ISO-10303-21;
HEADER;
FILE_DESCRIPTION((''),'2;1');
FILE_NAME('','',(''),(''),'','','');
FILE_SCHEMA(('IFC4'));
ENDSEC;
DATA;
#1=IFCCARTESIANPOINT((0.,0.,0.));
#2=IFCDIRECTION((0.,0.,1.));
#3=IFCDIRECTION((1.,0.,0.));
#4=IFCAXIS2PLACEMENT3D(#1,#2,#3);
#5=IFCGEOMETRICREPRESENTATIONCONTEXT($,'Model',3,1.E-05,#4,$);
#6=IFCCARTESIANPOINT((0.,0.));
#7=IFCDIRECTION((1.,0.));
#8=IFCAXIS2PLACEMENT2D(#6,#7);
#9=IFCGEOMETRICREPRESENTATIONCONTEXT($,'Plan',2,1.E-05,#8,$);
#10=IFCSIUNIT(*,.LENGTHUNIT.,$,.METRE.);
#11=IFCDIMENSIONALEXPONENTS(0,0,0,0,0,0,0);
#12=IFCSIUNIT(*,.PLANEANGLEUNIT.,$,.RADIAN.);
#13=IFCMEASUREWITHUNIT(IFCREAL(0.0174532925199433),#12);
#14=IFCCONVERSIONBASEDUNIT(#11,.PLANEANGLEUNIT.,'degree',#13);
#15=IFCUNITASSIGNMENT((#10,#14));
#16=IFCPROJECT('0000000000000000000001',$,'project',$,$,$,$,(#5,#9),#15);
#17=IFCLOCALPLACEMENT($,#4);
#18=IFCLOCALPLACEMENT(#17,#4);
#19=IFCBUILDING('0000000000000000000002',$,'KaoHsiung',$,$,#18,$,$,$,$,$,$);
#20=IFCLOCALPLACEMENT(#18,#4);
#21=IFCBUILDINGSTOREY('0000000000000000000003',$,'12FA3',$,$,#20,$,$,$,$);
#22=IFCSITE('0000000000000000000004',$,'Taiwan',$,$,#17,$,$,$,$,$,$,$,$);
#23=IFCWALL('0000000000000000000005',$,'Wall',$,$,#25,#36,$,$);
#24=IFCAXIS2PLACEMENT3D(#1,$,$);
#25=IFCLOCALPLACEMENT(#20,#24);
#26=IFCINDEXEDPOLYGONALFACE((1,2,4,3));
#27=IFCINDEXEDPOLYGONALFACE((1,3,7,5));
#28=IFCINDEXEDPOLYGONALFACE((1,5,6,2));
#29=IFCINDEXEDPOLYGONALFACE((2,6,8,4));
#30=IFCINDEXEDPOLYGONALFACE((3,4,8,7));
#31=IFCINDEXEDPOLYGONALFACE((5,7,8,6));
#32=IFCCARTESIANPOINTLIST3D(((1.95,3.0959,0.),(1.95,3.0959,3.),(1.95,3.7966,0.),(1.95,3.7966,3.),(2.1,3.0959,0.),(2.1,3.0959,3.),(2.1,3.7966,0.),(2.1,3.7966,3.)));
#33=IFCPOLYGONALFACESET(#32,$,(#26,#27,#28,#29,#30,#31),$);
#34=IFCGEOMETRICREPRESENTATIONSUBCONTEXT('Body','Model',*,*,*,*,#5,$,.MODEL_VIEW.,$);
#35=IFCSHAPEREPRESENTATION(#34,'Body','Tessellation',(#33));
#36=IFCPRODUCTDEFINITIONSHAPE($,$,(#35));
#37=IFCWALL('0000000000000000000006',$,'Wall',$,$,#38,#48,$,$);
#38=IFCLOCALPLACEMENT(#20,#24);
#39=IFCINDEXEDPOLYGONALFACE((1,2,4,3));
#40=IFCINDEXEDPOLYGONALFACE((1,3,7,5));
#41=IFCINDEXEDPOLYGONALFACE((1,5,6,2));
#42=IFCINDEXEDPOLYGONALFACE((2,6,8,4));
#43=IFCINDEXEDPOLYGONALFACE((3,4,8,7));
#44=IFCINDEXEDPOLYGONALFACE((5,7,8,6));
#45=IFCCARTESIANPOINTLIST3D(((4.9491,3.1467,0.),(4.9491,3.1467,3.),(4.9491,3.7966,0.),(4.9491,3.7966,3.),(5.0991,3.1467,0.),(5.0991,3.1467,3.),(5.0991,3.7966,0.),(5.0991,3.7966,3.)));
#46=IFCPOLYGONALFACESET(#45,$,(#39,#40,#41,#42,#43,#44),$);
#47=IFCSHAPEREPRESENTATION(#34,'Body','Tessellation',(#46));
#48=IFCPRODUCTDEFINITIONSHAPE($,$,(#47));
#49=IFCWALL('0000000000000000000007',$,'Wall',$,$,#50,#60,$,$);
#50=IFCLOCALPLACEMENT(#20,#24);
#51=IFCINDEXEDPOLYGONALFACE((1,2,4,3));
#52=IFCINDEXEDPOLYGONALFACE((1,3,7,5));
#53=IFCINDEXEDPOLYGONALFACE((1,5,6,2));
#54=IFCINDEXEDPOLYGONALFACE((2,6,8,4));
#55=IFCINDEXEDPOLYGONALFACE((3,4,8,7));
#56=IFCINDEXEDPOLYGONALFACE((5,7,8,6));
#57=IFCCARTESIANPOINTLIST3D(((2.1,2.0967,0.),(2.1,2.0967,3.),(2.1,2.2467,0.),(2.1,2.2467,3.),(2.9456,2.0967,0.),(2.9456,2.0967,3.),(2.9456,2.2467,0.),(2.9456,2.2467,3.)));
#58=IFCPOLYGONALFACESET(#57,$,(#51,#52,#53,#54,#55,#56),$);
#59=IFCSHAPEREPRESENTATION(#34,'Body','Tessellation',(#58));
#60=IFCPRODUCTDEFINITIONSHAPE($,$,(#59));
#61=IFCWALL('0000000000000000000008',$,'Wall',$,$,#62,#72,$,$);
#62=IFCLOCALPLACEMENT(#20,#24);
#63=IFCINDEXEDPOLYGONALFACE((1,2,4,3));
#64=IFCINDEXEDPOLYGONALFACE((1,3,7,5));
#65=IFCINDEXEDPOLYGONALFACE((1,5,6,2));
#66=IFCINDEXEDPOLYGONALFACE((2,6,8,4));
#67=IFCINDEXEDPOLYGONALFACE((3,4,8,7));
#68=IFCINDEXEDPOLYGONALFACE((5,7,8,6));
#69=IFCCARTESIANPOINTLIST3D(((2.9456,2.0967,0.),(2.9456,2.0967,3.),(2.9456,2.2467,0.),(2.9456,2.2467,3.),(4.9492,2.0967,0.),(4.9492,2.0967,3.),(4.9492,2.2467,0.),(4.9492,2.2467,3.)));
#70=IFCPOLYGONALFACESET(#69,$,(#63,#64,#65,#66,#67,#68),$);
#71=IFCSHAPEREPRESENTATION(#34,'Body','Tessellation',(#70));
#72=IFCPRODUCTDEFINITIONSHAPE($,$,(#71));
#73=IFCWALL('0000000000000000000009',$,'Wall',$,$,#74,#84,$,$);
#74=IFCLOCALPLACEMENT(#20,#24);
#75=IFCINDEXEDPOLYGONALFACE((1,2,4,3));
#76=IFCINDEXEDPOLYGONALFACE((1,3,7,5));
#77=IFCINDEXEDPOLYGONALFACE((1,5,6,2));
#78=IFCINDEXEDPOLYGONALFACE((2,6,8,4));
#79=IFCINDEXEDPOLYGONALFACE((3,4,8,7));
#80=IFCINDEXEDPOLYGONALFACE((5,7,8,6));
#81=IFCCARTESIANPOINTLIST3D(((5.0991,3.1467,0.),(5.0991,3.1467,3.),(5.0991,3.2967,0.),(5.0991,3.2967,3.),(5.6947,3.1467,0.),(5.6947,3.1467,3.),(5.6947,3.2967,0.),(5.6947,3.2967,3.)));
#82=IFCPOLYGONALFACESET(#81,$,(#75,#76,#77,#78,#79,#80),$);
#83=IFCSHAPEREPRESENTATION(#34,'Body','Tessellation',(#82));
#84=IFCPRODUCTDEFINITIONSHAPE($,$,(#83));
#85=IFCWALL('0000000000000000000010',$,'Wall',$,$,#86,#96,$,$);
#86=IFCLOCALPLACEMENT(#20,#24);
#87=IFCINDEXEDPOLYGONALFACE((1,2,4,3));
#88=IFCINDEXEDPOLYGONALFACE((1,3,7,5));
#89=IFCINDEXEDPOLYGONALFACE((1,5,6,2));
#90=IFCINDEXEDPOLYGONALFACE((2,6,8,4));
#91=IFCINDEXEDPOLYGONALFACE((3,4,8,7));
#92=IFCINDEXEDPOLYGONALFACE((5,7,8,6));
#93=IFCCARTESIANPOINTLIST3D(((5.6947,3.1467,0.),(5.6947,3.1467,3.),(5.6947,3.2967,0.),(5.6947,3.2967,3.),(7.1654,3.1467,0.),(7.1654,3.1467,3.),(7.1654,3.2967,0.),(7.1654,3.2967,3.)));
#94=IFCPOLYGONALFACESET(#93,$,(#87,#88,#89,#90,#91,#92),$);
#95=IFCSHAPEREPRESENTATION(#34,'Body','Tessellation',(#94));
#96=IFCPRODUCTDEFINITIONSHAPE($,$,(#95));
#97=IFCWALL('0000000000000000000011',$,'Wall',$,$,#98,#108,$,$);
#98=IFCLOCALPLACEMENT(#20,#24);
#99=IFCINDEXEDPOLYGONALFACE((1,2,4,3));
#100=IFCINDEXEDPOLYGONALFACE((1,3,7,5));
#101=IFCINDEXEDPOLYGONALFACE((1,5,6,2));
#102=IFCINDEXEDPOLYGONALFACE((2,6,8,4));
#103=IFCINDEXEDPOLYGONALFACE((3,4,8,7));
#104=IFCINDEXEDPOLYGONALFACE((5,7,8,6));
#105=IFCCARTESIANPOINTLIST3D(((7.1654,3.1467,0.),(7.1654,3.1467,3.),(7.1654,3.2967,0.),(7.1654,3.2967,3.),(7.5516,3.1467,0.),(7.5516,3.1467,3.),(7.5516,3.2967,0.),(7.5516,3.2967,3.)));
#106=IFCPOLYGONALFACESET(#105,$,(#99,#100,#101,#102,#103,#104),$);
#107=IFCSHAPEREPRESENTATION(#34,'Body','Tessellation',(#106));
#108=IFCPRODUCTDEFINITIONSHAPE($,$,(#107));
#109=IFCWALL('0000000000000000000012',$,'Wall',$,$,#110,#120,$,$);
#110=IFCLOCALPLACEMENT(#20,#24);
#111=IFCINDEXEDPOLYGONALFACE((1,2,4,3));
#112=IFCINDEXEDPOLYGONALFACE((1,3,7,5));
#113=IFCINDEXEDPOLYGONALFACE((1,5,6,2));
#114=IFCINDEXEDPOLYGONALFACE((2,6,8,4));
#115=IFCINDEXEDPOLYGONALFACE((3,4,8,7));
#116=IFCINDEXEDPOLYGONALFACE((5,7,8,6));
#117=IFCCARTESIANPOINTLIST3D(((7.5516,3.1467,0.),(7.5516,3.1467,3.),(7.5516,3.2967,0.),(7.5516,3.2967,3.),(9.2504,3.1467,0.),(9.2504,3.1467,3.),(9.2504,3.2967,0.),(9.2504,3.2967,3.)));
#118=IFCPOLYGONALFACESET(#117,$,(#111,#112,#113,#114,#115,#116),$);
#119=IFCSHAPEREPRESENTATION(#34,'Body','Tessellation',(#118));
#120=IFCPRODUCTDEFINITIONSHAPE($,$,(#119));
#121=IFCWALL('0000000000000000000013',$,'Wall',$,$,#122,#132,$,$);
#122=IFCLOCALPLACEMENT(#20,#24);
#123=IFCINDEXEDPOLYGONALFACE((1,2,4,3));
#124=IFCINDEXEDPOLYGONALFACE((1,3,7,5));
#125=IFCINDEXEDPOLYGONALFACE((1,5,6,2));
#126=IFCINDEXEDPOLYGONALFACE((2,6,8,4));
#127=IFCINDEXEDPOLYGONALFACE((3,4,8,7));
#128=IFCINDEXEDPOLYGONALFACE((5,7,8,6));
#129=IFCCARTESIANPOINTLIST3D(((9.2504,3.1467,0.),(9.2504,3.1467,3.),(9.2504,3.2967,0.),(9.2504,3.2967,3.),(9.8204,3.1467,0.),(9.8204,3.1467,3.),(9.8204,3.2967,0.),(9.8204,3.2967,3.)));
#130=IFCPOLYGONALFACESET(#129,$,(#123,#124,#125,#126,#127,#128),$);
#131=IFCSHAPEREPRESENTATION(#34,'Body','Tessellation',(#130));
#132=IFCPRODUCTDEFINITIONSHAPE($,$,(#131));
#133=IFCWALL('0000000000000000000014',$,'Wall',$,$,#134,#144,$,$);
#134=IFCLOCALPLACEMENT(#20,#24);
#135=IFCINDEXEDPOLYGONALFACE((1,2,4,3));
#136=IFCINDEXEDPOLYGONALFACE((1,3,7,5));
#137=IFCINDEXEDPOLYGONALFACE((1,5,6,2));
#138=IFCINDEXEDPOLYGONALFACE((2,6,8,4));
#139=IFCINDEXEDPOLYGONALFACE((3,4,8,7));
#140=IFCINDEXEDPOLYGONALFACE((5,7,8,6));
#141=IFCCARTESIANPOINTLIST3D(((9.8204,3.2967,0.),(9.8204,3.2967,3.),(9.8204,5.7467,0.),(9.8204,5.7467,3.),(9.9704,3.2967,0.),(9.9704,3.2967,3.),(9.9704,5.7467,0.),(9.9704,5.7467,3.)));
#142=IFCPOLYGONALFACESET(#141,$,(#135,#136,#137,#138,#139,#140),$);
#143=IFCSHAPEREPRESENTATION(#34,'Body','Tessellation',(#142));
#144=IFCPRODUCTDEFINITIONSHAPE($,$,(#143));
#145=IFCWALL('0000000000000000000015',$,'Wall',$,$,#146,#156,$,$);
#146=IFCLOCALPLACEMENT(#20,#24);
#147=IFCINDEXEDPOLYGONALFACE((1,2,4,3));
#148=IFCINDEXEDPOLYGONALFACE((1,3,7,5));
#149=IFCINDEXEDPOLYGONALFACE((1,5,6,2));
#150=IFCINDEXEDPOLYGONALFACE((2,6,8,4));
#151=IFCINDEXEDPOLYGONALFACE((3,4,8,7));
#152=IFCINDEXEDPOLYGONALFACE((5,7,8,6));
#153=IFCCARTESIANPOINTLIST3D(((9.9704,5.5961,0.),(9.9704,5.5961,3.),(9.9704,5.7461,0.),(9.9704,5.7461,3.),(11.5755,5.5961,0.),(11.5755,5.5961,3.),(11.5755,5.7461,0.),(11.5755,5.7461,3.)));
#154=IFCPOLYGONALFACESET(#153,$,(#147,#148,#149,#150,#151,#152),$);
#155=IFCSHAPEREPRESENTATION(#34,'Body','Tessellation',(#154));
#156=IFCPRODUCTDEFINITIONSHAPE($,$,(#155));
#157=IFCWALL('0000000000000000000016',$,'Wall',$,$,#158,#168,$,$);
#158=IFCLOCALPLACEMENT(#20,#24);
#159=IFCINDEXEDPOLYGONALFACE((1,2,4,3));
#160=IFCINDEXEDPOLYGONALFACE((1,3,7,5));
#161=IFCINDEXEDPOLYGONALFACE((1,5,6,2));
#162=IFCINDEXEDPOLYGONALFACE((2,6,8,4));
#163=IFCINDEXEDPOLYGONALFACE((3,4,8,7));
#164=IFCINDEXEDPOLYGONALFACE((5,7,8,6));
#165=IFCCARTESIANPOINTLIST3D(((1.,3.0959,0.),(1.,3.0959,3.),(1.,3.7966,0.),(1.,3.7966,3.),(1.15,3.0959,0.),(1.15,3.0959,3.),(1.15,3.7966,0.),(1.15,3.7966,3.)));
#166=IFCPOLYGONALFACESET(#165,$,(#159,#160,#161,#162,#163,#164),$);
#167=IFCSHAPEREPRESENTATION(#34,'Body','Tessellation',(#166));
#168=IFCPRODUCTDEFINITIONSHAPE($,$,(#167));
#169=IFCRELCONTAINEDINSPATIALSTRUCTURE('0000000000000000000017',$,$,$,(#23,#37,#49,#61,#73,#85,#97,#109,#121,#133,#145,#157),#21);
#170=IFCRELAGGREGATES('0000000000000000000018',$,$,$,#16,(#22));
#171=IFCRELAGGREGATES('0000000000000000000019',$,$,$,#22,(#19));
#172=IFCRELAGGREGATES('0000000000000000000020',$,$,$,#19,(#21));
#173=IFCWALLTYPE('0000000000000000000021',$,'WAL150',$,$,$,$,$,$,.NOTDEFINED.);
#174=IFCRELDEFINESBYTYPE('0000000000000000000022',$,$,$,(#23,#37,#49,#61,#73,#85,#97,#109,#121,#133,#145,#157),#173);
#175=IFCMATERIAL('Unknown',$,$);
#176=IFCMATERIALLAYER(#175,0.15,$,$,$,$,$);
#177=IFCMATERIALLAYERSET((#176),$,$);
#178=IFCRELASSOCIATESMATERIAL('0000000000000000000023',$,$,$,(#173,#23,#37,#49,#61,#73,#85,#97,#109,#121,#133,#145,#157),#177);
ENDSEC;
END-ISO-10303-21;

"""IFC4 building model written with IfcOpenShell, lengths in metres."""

from ifc_helpers import new_model, entity, si_unit, converted_unit, frame, origin_with_axes, origin_2d_with_axis, place, context, subcontext, project, spatial, line, indexed_curve, outline, extrude, material, layer, layer_set, layer_usage, type_object, element, save


model = new_model("IFC4")

# Units and contexts
model_context = context("Model", 3, precision=1e-05, world=origin_with_axes())
plan_context = context("Plan", 2, precision=1e-05, world=origin_2d_with_axis())
body_context = subcontext(model_context, "Body", "Model", "MODEL_VIEW")
ifc_project = project(units=[si_unit("LENGTHUNIT", "METRE"), converted_unit("PLANEANGLEUNIT", "degree", entity("IfcReal", 0.0174532925199433), si_unit("PLANEANGLEUNIT", "RADIAN"), dimensions=[0, 0, 0, 0, 0, 0, 0])], contexts=[model_context, plan_context])

# Site, building, storey
site_placement = place(None, origin_with_axes())
site = spatial("IfcSite", under=ifc_project, at=site_placement, Name="Taiwan")
building_placement = place(site_placement, origin_with_axes())
building = spatial("IfcBuilding", under=site, at=building_placement, Name="KaoHsiung")
storey_placement = place(building_placement, origin_with_axes())
storey = spatial("IfcBuildingStorey", under=building, at=storey_placement, Name="12FA3")

# Shared definitions
ifc_material = material(Name="Unknown")

# Walls
ifc_layer_1 = layer(ifc_material, 0.15)
ifc_layer_set_1 = layer_set([ifc_layer_1])
wall_type_1 = type_object("IfcWallType", Name="WAL150", PredefinedType="NOTDEFINED", material=ifc_layer_set_1)
ifc_layer_usage_1 = layer_usage(ifc_layer_set_1, "AXIS2", "POSITIVE", 0.0)
wall_1_placement = place(storey_placement, frame((1.95, 3.7966, 0.0), z_axis=(0.0, 0.0, 1.0), x_axis=(0.0, -1.0, 0.0)))
element("IfcWall", 1, at=wall_1_placement, inside=storey, type_object=wall_type_1, material=ifc_layer_usage_1, Name="Wall", context=body_context, shape_type="SweptSolid", body=[
    extrude(outline(indexed_curve([(0.0, 0.0), (0.0, 0.15), (0.7007, 0.15), (0.7007, 0.0)], segments=[line(1, 2, 3, 4, 1)])), origin_with_axes(), (0.0, 0.0, 1.0), 3.0),
])
ifc_layer_usage_2 = layer_usage(ifc_layer_set_1, "AXIS2", "POSITIVE", 0.0)
wall_2_placement = place(storey_placement, frame((4.9491, 3.7966, 0.0), z_axis=(0.0, 0.0, 1.0), x_axis=(0.0, -1.0, 0.0)))
element("IfcWall", 2, at=wall_2_placement, inside=storey, type_object=wall_type_1, material=ifc_layer_usage_2, Name="Wall", context=body_context, shape_type="SweptSolid", body=[
    extrude(outline(indexed_curve([(0.0, 0.0), (0.0, 0.15), (0.6499, 0.15), (0.6499, 0.0)], segments=[line(1, 2, 3, 4, 1)])), origin_with_axes(), (0.0, 0.0, 1.0), 3.0),
])
ifc_layer_usage_3 = layer_usage(ifc_layer_set_1, "AXIS2", "POSITIVE", 0.0)
wall_3_placement = place(storey_placement, frame((2.1, 2.0967, 0.0), z_axis=(0.0, 0.0, 1.0), x_axis=(1.0, 0.0, 0.0)))
element("IfcWall", 3, at=wall_3_placement, inside=storey, type_object=wall_type_1, material=ifc_layer_usage_3, Name="Wall", context=body_context, shape_type="SweptSolid", body=[
    extrude(outline(indexed_curve([(0.0, 0.0), (0.0, 0.15), (0.8456, 0.15), (0.8456, 0.0)], segments=[line(1, 2, 3, 4, 1)])), origin_with_axes(), (0.0, 0.0, 1.0), 3.0),
])
ifc_layer_usage_4 = layer_usage(ifc_layer_set_1, "AXIS2", "POSITIVE", 0.0)
wall_4_placement = place(storey_placement, frame((2.9456, 2.0967, 0.0), z_axis=(0.0, 0.0, 1.0), x_axis=(1.0, 0.0, 0.0)))
element("IfcWall", 4, at=wall_4_placement, inside=storey, type_object=wall_type_1, material=ifc_layer_usage_4, Name="Wall", context=body_context, shape_type="SweptSolid", body=[
    extrude(outline(indexed_curve([(0.0, 0.0), (0.0, 0.15), (2.0037, 0.15), (2.0037, 0.0)], segments=[line(1, 2, 3, 4, 1)])), origin_with_axes(), (0.0, 0.0, 1.0), 3.0),
])
ifc_layer_usage_5 = layer_usage(ifc_layer_set_1, "AXIS2", "POSITIVE", 0.0)
wall_5_placement = place(storey_placement, frame((5.0991, 3.1467, 0.0), z_axis=(0.0, 0.0, 1.0), x_axis=(1.0, 0.0, 0.0)))
element("IfcWall", 5, at=wall_5_placement, inside=storey, type_object=wall_type_1, material=ifc_layer_usage_5, Name="Wall", context=body_context, shape_type="SweptSolid", body=[
    extrude(outline(indexed_curve([(0.0, 0.0), (0.0, 0.15), (0.5956, 0.15), (0.5956, 0.0)], segments=[line(1, 2, 3, 4, 1)])), origin_with_axes(), (0.0, 0.0, 1.0), 3.0),
])
ifc_layer_usage_6 = layer_usage(ifc_layer_set_1, "AXIS2", "POSITIVE", 0.0)
wall_6_placement = place(storey_placement, frame((5.6947, 3.1467, 0.0), z_axis=(0.0, 0.0, 1.0), x_axis=(1.0, 0.0, 0.0)))
element("IfcWall", 6, at=wall_6_placement, inside=storey, type_object=wall_type_1, material=ifc_layer_usage_6, Name="Wall", context=body_context, shape_type="SweptSolid", body=[
    extrude(outline(indexed_curve([(0.0, 0.0), (0.0, 0.15), (1.4706, 0.15), (1.4706, 0.0)], segments=[line(1, 2, 3, 4, 1)])), origin_with_axes(), (0.0, 0.0, 1.0), 3.0),
])
ifc_layer_usage_7 = layer_usage(ifc_layer_set_1, "AXIS2", "POSITIVE", 0.0)
wall_7_placement = place(storey_placement, frame((7.1654, 3.1467, 0.0), z_axis=(0.0, 0.0, 1.0), x_axis=(1.0, 0.0, 0.0)))
element("IfcWall", 7, at=wall_7_placement, inside=storey, type_object=wall_type_1, material=ifc_layer_usage_7, Name="Wall", context=body_context, shape_type="SweptSolid", body=[
    extrude(outline(indexed_curve([(0.0, 0.0), (0.0, 0.15), (0.3862, 0.15), (0.3862, 0.0)], segments=[line(1, 2, 3, 4, 1)])), origin_with_axes(), (0.0, 0.0, 1.0), 3.0),
])
ifc_layer_usage_8 = layer_usage(ifc_layer_set_1, "AXIS2", "POSITIVE", 0.0)
wall_8_placement = place(storey_placement, frame((7.5516, 3.1467, 0.0), z_axis=(0.0, 0.0, 1.0), x_axis=(1.0, 0.0, 0.0)))
element("IfcWall", 8, at=wall_8_placement, inside=storey, type_object=wall_type_1, material=ifc_layer_usage_8, Name="Wall", context=body_context, shape_type="SweptSolid", body=[
    extrude(outline(indexed_curve([(0.0, 0.0), (0.0, 0.15), (1.6987, 0.15), (1.6987, 0.0)], segments=[line(1, 2, 3, 4, 1)])), origin_with_axes(), (0.0, 0.0, 1.0), 3.0),
])
ifc_layer_usage_9 = layer_usage(ifc_layer_set_1, "AXIS2", "POSITIVE", 0.0)
wall_9_placement = place(storey_placement, frame((9.2504, 3.1467, 0.0), z_axis=(0.0, 0.0, 1.0), x_axis=(1.0, 0.0, 0.0)))
element("IfcWall", 9, at=wall_9_placement, inside=storey, type_object=wall_type_1, material=ifc_layer_usage_9, Name="Wall", context=body_context, shape_type="SweptSolid", body=[
    extrude(outline(indexed_curve([(0.0, 0.0), (0.0, 0.15), (0.57, 0.15), (0.57, 0.0)], segments=[line(1, 2, 3, 4, 1)])), origin_with_axes(), (0.0, 0.0, 1.0), 3.0),
])
ifc_layer_usage_10 = layer_usage(ifc_layer_set_1, "AXIS2", "POSITIVE", 0.0)
wall_10_placement = place(storey_placement, frame((9.9704, 3.2967, 0.0), z_axis=(0.0, 0.0, 1.0), x_axis=(0.0, 1.0, 0.0)))
element("IfcWall", 10, at=wall_10_placement, inside=storey, type_object=wall_type_1, material=ifc_layer_usage_10, Name="Wall", context=body_context, shape_type="SweptSolid", body=[
    extrude(outline(indexed_curve([(0.0, 0.0), (0.0, 0.15), (2.45, 0.15), (2.45, 0.0)], segments=[line(1, 2, 3, 4, 1)])), origin_with_axes(), (0.0, 0.0, 1.0), 3.0),
])
ifc_layer_usage_11 = layer_usage(ifc_layer_set_1, "AXIS2", "POSITIVE", 0.0)
wall_11_placement = place(storey_placement, frame((9.9704, 5.5961, 0.0), z_axis=(0.0, 0.0, 1.0), x_axis=(1.0, 0.0, 0.0)))
element("IfcWall", 11, at=wall_11_placement, inside=storey, type_object=wall_type_1, material=ifc_layer_usage_11, Name="Wall", context=body_context, shape_type="SweptSolid", body=[
    extrude(outline(indexed_curve([(0.0, 0.0), (0.0, 0.15), (1.6051, 0.15), (1.6051, 0.0)], segments=[line(1, 2, 3, 4, 1)])), origin_with_axes(), (0.0, 0.0, 1.0), 3.0),
])
ifc_layer_usage_12 = layer_usage(ifc_layer_set_1, "AXIS2", "POSITIVE", 0.0)
wall_12_placement = place(storey_placement, frame((1.0, 3.7966, 0.0), z_axis=(0.0, 0.0, 1.0), x_axis=(0.0, -1.0, 0.0)))
element("IfcWall", 12, at=wall_12_placement, inside=storey, type_object=wall_type_1, material=ifc_layer_usage_12, Name="Wall", context=body_context, shape_type="SweptSolid", body=[
    extrude(outline(indexed_curve([(0.0, 0.0), (0.0, 0.15), (0.7007, 0.15), (0.7007, 0.0)], segments=[line(1, 2, 3, 4, 1)])), origin_with_axes(), (0.0, 0.0, 1.0), 3.0),
])

save(model, "model.ifc")
